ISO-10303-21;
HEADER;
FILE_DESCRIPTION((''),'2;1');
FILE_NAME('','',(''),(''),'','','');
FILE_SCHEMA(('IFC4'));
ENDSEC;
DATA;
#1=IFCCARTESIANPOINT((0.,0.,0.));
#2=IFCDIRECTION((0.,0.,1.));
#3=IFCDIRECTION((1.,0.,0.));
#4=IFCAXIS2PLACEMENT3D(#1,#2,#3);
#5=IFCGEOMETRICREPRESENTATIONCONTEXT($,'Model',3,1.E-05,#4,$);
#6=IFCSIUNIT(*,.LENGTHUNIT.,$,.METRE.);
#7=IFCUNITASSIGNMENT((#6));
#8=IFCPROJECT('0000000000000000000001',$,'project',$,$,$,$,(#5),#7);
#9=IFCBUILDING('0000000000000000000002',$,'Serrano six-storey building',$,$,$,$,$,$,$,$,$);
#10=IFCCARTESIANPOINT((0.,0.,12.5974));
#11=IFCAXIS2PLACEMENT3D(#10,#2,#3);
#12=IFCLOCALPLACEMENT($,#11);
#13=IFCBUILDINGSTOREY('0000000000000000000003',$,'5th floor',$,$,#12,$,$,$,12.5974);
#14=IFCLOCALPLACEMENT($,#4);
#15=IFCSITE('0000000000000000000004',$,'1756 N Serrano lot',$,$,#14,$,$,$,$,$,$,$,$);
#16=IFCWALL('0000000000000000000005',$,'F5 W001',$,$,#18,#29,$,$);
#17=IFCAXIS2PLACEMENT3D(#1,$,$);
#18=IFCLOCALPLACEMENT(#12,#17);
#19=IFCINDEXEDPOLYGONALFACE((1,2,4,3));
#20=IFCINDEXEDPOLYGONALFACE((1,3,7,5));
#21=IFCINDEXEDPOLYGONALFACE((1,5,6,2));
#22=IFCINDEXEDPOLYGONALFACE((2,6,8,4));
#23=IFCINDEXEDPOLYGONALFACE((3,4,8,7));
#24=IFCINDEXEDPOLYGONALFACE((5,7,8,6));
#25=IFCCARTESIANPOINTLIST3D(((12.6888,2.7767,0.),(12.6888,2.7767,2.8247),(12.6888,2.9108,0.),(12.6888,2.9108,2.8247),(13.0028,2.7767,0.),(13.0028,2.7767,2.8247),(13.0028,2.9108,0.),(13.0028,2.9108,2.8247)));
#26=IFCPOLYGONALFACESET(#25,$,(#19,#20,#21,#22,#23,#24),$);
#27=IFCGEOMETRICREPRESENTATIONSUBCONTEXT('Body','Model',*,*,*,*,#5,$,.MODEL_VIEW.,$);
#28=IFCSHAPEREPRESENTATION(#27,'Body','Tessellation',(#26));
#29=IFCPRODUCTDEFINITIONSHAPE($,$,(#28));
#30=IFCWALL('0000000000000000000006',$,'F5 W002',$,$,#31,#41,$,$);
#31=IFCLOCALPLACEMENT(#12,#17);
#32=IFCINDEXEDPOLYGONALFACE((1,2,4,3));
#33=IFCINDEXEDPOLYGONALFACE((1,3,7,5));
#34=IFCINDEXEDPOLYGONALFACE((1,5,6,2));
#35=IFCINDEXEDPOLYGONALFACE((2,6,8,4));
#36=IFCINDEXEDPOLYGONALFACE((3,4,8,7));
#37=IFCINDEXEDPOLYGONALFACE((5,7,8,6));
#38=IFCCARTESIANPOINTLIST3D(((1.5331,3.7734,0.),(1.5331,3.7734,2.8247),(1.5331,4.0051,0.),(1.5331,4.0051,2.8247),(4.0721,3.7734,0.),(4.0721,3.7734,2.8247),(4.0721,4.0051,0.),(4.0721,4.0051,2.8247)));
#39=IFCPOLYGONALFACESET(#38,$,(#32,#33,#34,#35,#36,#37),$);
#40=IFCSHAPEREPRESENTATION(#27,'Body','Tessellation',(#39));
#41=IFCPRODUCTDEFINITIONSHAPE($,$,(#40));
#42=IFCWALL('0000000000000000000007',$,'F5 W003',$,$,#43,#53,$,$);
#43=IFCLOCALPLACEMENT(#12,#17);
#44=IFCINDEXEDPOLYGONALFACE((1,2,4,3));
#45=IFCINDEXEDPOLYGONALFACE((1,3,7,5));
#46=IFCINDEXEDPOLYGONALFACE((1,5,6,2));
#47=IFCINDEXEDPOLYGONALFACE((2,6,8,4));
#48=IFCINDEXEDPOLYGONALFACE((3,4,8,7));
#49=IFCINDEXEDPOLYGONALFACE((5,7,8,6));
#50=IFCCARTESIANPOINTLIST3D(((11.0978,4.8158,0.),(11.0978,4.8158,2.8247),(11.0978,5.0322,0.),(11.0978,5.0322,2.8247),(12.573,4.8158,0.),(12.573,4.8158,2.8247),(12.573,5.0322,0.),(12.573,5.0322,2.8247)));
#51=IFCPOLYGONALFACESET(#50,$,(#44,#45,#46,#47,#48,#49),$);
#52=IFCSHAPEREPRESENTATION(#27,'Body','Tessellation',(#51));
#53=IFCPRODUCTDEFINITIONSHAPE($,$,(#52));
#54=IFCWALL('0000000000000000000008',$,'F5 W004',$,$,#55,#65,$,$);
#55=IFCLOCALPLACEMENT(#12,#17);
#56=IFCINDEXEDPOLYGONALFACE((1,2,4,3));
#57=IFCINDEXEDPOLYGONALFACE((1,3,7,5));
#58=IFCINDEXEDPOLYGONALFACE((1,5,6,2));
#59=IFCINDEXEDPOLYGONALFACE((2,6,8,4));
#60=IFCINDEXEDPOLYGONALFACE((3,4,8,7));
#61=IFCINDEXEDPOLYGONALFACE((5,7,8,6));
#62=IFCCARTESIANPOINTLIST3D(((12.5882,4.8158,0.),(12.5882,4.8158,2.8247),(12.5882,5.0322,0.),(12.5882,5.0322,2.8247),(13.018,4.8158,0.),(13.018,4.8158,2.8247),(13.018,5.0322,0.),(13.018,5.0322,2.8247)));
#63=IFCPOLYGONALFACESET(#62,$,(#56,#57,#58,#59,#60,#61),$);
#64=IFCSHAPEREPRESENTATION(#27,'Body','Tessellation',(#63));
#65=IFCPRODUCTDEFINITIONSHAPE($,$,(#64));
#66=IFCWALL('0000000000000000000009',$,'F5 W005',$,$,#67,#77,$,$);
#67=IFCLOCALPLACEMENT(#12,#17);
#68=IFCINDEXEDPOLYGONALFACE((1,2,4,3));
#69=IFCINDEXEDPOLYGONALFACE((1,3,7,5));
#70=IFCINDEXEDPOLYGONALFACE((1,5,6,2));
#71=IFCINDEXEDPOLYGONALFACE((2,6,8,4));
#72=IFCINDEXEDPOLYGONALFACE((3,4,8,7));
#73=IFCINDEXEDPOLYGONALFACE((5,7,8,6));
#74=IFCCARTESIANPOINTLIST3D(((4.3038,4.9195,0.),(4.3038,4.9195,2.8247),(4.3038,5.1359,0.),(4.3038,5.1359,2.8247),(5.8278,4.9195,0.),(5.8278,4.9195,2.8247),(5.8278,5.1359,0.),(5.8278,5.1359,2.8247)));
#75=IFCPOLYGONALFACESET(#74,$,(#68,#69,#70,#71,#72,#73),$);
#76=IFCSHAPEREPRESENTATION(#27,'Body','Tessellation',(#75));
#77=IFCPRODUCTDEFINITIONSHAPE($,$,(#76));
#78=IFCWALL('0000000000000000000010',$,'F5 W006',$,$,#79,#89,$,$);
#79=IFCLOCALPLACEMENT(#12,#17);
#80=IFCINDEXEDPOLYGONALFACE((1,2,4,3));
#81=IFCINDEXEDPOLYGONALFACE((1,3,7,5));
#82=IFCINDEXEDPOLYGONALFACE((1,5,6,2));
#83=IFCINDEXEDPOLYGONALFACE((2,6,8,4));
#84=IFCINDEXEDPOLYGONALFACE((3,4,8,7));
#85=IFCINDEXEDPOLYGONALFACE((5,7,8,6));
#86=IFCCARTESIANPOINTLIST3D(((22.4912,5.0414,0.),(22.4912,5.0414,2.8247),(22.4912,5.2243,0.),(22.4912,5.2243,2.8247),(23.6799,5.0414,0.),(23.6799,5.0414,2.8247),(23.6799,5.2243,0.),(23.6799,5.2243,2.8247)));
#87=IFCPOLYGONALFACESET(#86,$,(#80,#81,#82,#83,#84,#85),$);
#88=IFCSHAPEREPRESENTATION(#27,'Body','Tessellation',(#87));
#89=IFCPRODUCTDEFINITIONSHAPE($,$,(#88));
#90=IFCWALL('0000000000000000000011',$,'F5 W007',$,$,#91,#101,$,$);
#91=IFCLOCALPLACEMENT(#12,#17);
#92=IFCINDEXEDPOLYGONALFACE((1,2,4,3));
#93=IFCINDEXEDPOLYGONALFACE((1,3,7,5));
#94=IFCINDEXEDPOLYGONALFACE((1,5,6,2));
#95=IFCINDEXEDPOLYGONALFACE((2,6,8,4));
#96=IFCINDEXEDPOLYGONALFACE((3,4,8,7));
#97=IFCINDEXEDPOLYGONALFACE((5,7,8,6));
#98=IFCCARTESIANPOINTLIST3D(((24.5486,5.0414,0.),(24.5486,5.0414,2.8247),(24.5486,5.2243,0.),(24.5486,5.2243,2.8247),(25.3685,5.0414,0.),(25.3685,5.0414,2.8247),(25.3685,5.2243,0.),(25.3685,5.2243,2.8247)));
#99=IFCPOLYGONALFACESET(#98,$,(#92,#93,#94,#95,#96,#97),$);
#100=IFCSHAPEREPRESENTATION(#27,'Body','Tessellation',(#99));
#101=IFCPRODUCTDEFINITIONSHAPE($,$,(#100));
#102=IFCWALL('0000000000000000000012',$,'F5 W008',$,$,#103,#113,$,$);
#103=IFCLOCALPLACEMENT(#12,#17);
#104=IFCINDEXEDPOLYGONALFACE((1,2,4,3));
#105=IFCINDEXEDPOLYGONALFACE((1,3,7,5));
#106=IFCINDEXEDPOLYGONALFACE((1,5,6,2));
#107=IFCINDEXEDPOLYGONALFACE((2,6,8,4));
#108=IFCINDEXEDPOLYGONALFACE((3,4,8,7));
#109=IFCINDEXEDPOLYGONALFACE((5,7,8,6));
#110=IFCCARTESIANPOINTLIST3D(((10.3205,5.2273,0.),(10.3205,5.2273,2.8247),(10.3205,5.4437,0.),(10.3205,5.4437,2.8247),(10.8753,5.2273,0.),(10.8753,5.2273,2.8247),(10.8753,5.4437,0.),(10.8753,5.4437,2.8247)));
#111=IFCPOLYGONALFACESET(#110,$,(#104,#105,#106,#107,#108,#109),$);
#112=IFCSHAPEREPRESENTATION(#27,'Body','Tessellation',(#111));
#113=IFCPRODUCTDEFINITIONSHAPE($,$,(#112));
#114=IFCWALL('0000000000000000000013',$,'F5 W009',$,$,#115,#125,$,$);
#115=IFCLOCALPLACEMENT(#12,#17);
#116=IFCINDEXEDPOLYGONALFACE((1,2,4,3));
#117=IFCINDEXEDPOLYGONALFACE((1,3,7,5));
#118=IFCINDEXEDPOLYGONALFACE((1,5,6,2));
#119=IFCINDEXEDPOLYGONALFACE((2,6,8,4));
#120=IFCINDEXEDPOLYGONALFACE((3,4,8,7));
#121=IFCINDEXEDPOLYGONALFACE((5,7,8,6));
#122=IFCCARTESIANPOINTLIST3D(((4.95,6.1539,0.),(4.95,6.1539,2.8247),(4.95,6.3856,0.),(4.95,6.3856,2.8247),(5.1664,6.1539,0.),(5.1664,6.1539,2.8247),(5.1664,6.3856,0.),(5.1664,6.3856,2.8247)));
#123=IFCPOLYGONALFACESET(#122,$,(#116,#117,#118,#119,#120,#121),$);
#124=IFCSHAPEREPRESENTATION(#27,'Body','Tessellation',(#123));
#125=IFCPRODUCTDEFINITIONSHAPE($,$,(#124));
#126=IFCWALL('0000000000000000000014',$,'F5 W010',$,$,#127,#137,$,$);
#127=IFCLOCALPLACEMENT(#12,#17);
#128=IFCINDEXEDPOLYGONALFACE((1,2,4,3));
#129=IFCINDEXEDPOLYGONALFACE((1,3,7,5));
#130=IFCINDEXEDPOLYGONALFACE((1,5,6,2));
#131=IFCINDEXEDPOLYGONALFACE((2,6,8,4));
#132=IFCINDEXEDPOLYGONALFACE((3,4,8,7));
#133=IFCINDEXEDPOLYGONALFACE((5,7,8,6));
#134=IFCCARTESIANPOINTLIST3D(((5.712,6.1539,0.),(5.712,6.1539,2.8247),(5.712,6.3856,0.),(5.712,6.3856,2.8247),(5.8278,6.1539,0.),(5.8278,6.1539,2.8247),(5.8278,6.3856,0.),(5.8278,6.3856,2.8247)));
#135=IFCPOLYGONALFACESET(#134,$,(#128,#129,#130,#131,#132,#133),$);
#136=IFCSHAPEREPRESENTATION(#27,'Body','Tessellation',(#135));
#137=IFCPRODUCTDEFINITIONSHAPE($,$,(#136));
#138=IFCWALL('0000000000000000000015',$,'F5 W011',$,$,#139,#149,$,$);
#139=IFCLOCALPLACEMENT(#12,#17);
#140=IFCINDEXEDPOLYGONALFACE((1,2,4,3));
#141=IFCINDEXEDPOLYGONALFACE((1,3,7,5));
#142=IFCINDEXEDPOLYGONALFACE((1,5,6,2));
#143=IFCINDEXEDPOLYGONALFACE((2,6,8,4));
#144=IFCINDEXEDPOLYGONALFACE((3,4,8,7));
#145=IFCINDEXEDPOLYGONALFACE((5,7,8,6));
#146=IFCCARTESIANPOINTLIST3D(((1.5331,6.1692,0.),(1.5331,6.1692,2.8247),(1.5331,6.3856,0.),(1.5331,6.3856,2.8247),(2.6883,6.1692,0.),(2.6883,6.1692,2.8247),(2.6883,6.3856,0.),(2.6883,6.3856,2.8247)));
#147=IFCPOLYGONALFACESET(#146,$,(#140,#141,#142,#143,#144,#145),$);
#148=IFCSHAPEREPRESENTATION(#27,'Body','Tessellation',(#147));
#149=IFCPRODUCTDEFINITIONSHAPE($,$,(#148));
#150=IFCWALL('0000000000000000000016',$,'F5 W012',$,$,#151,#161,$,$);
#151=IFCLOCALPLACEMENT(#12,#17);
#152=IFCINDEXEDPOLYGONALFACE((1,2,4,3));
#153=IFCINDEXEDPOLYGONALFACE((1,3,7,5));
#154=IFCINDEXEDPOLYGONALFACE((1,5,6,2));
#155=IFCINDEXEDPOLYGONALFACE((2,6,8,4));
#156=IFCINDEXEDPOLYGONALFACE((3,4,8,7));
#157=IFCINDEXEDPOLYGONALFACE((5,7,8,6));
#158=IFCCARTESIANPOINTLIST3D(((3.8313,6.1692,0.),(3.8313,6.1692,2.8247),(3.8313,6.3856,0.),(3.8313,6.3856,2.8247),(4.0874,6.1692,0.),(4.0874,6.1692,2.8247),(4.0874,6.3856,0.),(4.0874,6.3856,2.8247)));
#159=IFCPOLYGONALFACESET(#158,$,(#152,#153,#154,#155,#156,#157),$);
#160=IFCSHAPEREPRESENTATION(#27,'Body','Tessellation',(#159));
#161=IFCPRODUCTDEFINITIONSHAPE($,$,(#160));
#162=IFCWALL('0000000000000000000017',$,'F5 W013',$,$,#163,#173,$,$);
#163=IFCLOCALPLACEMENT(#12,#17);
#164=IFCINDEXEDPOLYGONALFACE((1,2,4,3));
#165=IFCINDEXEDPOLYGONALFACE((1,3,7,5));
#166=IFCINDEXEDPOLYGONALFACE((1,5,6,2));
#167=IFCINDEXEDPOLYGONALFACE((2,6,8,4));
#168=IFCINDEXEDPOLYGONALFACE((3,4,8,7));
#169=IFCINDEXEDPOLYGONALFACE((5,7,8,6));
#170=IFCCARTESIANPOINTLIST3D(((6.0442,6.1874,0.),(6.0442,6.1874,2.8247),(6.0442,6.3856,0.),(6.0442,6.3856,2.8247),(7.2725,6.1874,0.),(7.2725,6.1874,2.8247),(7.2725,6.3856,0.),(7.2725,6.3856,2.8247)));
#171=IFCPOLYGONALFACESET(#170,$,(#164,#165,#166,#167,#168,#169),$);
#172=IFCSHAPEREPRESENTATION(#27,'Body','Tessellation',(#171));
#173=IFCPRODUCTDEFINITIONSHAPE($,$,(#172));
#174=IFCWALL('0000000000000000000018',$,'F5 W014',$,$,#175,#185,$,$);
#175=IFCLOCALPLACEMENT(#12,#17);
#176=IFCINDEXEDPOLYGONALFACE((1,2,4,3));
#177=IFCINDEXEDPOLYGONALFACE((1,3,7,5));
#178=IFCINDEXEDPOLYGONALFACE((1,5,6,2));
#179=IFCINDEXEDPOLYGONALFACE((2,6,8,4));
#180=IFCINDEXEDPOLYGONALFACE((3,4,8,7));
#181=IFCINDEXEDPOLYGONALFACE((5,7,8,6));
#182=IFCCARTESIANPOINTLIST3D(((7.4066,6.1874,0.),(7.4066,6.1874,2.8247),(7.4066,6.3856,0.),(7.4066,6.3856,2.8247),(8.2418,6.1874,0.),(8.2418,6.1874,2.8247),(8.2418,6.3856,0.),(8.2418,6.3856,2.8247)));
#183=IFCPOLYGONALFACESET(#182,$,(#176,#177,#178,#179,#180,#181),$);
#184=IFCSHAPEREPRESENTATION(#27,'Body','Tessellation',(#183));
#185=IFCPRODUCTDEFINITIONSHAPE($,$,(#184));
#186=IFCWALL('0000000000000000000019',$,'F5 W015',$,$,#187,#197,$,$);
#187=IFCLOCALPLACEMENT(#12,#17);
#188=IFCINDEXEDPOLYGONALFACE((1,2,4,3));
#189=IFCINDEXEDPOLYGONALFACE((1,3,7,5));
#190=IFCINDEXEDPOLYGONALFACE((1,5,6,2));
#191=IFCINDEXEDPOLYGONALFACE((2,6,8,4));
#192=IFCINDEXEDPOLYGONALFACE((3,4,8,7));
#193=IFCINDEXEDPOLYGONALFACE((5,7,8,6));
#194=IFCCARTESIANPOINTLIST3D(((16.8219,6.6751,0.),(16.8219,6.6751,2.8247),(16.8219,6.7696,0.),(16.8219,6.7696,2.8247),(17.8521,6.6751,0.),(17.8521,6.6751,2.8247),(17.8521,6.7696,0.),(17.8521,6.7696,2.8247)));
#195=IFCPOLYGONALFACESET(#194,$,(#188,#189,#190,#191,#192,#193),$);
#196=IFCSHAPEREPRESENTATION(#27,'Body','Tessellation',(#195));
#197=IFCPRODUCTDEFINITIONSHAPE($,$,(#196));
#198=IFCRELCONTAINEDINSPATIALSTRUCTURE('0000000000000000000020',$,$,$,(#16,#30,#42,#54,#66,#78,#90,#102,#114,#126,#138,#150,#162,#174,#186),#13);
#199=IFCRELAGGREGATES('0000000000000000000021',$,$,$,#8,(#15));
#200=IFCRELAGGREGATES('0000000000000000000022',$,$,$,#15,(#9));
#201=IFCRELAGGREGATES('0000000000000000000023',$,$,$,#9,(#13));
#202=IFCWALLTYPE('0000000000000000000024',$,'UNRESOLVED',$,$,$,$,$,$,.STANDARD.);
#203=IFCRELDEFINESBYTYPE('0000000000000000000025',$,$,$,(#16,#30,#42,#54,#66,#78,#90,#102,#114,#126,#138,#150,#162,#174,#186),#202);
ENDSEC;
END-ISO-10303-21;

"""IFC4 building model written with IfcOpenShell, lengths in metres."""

from ifc_helpers import new_model, si_unit, frame, origin_with_axes, place, context, subcontext, project, spatial, polyline, outline, extrude, type_object, element, save


model = new_model("IFC4")

# Units and contexts
model_context = context("Model", 3, precision=1e-05, world=origin_with_axes())
body_context = subcontext(model_context, "Body", "Model", "MODEL_VIEW")
ifc_project = project(units=[si_unit("LENGTHUNIT", "METRE")], contexts=[model_context])

# Site, building, storey
site_placement = place(None, origin_with_axes())
site = spatial("IfcSite", under=ifc_project, at=site_placement, Name="1756 N Serrano lot")
building = spatial("IfcBuilding", under=site, Name="Serrano six-storey building")
storey_placement = place(None, frame((0.0, 0.0, 12.5974), z_axis=(0.0, 0.0, 1.0), x_axis=(1.0, 0.0, 0.0)))
storey = spatial("IfcBuildingStorey", under=building, at=storey_placement, Name="5th floor", Elevation=12.5974)

# Walls
wall_type = type_object("IfcWallType", Name="UNRESOLVED", PredefinedType="STANDARD")
wall_1_placement = place(storey_placement, frame((0.0, 0.0, -12.5974), z_axis=(0.0, 0.0, 1.0), x_axis=(1.0, 0.0, 0.0)))
element("IfcWall", 1, at=wall_1_placement, inside=storey, type_object=wall_type, Name="F5 W001", context=body_context, shape_type="SweptSolid", body=[
    extrude(outline(polyline([(13.0028, 2.9108), (13.0028, 2.7767), (12.6888, 2.7767), (12.6888, 2.9108), (13.0028, 2.9108)])), frame((0.0, 0.0, 12.5974)), (0.0, 0.0, 1.0), 2.8247),
])
wall_2_placement = place(storey_placement, frame((0.0, 0.0, -12.5974), z_axis=(0.0, 0.0, 1.0), x_axis=(1.0, 0.0, 0.0)))
element("IfcWall", 2, at=wall_2_placement, inside=storey, type_object=wall_type, Name="F5 W002", context=body_context, shape_type="SweptSolid", body=[
    extrude(outline(polyline([(4.0721, 4.0051), (4.0721, 3.7734), (1.5331, 3.7734), (1.5331, 4.0051), (4.0721, 4.0051)])), frame((0.0, 0.0, 12.5974)), (0.0, 0.0, 1.0), 2.8247),
])
wall_3_placement = place(storey_placement, frame((0.0, 0.0, -12.5974), z_axis=(0.0, 0.0, 1.0), x_axis=(1.0, 0.0, 0.0)))
element("IfcWall", 3, at=wall_3_placement, inside=storey, type_object=wall_type, Name="F5 W003", context=body_context, shape_type="SweptSolid", body=[
    extrude(outline(polyline([(12.573, 5.0322), (12.573, 4.8158), (11.0978, 4.8158), (11.0978, 5.0322), (12.573, 5.0322)])), frame((0.0, 0.0, 12.5974)), (0.0, 0.0, 1.0), 2.8247),
])
wall_4_placement = place(storey_placement, frame((0.0, 0.0, -12.5974), z_axis=(0.0, 0.0, 1.0), x_axis=(1.0, 0.0, 0.0)))
element("IfcWall", 4, at=wall_4_placement, inside=storey, type_object=wall_type, Name="F5 W004", context=body_context, shape_type="SweptSolid", body=[
    extrude(outline(polyline([(13.018, 5.0322), (13.018, 4.8158), (12.5882, 4.8158), (12.5882, 5.0322), (13.018, 5.0322)])), frame((0.0, 0.0, 12.5974)), (0.0, 0.0, 1.0), 2.8247),
])
wall_5_placement = place(storey_placement, frame((0.0, 0.0, -12.5974), z_axis=(0.0, 0.0, 1.0), x_axis=(1.0, 0.0, 0.0)))
element("IfcWall", 5, at=wall_5_placement, inside=storey, type_object=wall_type, Name="F5 W005", context=body_context, shape_type="SweptSolid", body=[
    extrude(outline(polyline([(5.8278, 5.1359), (5.8278, 4.9195), (4.3038, 4.9195), (4.3038, 5.1359), (5.8278, 5.1359)])), frame((0.0, 0.0, 12.5974)), (0.0, 0.0, 1.0), 2.8247),
])
wall_6_placement = place(storey_placement, frame((0.0, 0.0, -12.5974), z_axis=(0.0, 0.0, 1.0), x_axis=(1.0, 0.0, 0.0)))
element("IfcWall", 6, at=wall_6_placement, inside=storey, type_object=wall_type, Name="F5 W006", context=body_context, shape_type="SweptSolid", body=[
    extrude(outline(polyline([(23.6799, 5.2243), (23.6799, 5.0414), (22.4912, 5.0414), (22.4912, 5.2243), (23.6799, 5.2243)])), frame((0.0, 0.0, 12.5974)), (0.0, 0.0, 1.0), 2.8247),
])
wall_7_placement = place(storey_placement, frame((0.0, 0.0, -12.5974), z_axis=(0.0, 0.0, 1.0), x_axis=(1.0, 0.0, 0.0)))
element("IfcWall", 7, at=wall_7_placement, inside=storey, type_object=wall_type, Name="F5 W007", context=body_context, shape_type="SweptSolid", body=[
    extrude(outline(polyline([(25.3685, 5.2243), (25.3685, 5.0414), (24.5486, 5.0414), (24.5486, 5.2243), (25.3685, 5.2243)])), frame((0.0, 0.0, 12.5974)), (0.0, 0.0, 1.0), 2.8247),
])
wall_8_placement = place(storey_placement, frame((0.0, 0.0, -12.5974), z_axis=(0.0, 0.0, 1.0), x_axis=(1.0, 0.0, 0.0)))
element("IfcWall", 8, at=wall_8_placement, inside=storey, type_object=wall_type, Name="F5 W008", context=body_context, shape_type="SweptSolid", body=[
    extrude(outline(polyline([(10.8753, 5.4437), (10.8753, 5.2273), (10.3205, 5.2273), (10.3205, 5.4437), (10.8753, 5.4437)])), frame((0.0, 0.0, 12.5974)), (0.0, 0.0, 1.0), 2.8247),
])
wall_9_placement = place(storey_placement, frame((0.0, 0.0, -12.5974), z_axis=(0.0, 0.0, 1.0), x_axis=(1.0, 0.0, 0.0)))
element("IfcWall", 9, at=wall_9_placement, inside=storey, type_object=wall_type, Name="F5 W009", context=body_context, shape_type="SweptSolid", body=[
    extrude(outline(polyline([(5.1664, 6.3856), (5.1664, 6.1539), (4.95, 6.1539), (4.95, 6.3856), (5.1664, 6.3856)])), frame((0.0, 0.0, 12.5974)), (0.0, 0.0, 1.0), 2.8247),
])
wall_10_placement = place(storey_placement, frame((0.0, 0.0, -12.5974), z_axis=(0.0, 0.0, 1.0), x_axis=(1.0, 0.0, 0.0)))
element("IfcWall", 10, at=wall_10_placement, inside=storey, type_object=wall_type, Name="F5 W010", context=body_context, shape_type="SweptSolid", body=[
    extrude(outline(polyline([(5.8278, 6.3856), (5.8278, 6.1539), (5.712, 6.1539), (5.712, 6.3856), (5.8278, 6.3856)])), frame((0.0, 0.0, 12.5974)), (0.0, 0.0, 1.0), 2.8247),
])
wall_11_placement = place(storey_placement, frame((0.0, 0.0, -12.5974), z_axis=(0.0, 0.0, 1.0), x_axis=(1.0, 0.0, 0.0)))
element("IfcWall", 11, at=wall_11_placement, inside=storey, type_object=wall_type, Name="F5 W011", context=body_context, shape_type="SweptSolid", body=[
    extrude(outline(polyline([(2.6883, 6.3856), (2.6883, 6.1692), (1.5331, 6.1692), (1.5331, 6.3856), (2.6883, 6.3856)])), frame((0.0, 0.0, 12.5974)), (0.0, 0.0, 1.0), 2.8247),
])
wall_12_placement = place(storey_placement, frame((0.0, 0.0, -12.5974), z_axis=(0.0, 0.0, 1.0), x_axis=(1.0, 0.0, 0.0)))
element("IfcWall", 12, at=wall_12_placement, inside=storey, type_object=wall_type, Name="F5 W012", context=body_context, shape_type="SweptSolid", body=[
    extrude(outline(polyline([(4.0874, 6.3856), (4.0874, 6.1692), (3.8313, 6.1692), (3.8313, 6.3856), (4.0874, 6.3856)])), frame((0.0, 0.0, 12.5974)), (0.0, 0.0, 1.0), 2.8247),
])
wall_13_placement = place(storey_placement, frame((0.0, 0.0, -12.5974), z_axis=(0.0, 0.0, 1.0), x_axis=(1.0, 0.0, 0.0)))
element("IfcWall", 13, at=wall_13_placement, inside=storey, type_object=wall_type, Name="F5 W013", context=body_context, shape_type="SweptSolid", body=[
    extrude(outline(polyline([(7.2725, 6.3856), (7.2725, 6.1874), (6.0442, 6.1874), (6.0442, 6.3856), (7.2725, 6.3856)])), frame((0.0, 0.0, 12.5974)), (0.0, 0.0, 1.0), 2.8247),
])
wall_14_placement = place(storey_placement, frame((0.0, 0.0, -12.5974), z_axis=(0.0, 0.0, 1.0), x_axis=(1.0, 0.0, 0.0)))
element("IfcWall", 14, at=wall_14_placement, inside=storey, type_object=wall_type, Name="F5 W014", context=body_context, shape_type="SweptSolid", body=[
    extrude(outline(polyline([(8.2418, 6.3856), (8.2418, 6.1874), (7.4066, 6.1874), (7.4066, 6.3856), (8.2418, 6.3856)])), frame((0.0, 0.0, 12.5974)), (0.0, 0.0, 1.0), 2.8247),
])
wall_15_placement = place(storey_placement, frame((0.0, 0.0, -12.5974), z_axis=(0.0, 0.0, 1.0), x_axis=(1.0, 0.0, 0.0)))
element("IfcWall", 15, at=wall_15_placement, inside=storey, type_object=wall_type, Name="F5 W015", context=body_context, shape_type="SweptSolid", body=[
    extrude(outline(polyline([(17.8521, 6.7696), (17.8521, 6.6751), (16.8219, 6.6751), (16.8219, 6.7696), (17.8521, 6.7696)])), frame((0.0, 0.0, 12.5974)), (0.0, 0.0, 1.0), 2.8247),
])

save(model, "model.ifc")
